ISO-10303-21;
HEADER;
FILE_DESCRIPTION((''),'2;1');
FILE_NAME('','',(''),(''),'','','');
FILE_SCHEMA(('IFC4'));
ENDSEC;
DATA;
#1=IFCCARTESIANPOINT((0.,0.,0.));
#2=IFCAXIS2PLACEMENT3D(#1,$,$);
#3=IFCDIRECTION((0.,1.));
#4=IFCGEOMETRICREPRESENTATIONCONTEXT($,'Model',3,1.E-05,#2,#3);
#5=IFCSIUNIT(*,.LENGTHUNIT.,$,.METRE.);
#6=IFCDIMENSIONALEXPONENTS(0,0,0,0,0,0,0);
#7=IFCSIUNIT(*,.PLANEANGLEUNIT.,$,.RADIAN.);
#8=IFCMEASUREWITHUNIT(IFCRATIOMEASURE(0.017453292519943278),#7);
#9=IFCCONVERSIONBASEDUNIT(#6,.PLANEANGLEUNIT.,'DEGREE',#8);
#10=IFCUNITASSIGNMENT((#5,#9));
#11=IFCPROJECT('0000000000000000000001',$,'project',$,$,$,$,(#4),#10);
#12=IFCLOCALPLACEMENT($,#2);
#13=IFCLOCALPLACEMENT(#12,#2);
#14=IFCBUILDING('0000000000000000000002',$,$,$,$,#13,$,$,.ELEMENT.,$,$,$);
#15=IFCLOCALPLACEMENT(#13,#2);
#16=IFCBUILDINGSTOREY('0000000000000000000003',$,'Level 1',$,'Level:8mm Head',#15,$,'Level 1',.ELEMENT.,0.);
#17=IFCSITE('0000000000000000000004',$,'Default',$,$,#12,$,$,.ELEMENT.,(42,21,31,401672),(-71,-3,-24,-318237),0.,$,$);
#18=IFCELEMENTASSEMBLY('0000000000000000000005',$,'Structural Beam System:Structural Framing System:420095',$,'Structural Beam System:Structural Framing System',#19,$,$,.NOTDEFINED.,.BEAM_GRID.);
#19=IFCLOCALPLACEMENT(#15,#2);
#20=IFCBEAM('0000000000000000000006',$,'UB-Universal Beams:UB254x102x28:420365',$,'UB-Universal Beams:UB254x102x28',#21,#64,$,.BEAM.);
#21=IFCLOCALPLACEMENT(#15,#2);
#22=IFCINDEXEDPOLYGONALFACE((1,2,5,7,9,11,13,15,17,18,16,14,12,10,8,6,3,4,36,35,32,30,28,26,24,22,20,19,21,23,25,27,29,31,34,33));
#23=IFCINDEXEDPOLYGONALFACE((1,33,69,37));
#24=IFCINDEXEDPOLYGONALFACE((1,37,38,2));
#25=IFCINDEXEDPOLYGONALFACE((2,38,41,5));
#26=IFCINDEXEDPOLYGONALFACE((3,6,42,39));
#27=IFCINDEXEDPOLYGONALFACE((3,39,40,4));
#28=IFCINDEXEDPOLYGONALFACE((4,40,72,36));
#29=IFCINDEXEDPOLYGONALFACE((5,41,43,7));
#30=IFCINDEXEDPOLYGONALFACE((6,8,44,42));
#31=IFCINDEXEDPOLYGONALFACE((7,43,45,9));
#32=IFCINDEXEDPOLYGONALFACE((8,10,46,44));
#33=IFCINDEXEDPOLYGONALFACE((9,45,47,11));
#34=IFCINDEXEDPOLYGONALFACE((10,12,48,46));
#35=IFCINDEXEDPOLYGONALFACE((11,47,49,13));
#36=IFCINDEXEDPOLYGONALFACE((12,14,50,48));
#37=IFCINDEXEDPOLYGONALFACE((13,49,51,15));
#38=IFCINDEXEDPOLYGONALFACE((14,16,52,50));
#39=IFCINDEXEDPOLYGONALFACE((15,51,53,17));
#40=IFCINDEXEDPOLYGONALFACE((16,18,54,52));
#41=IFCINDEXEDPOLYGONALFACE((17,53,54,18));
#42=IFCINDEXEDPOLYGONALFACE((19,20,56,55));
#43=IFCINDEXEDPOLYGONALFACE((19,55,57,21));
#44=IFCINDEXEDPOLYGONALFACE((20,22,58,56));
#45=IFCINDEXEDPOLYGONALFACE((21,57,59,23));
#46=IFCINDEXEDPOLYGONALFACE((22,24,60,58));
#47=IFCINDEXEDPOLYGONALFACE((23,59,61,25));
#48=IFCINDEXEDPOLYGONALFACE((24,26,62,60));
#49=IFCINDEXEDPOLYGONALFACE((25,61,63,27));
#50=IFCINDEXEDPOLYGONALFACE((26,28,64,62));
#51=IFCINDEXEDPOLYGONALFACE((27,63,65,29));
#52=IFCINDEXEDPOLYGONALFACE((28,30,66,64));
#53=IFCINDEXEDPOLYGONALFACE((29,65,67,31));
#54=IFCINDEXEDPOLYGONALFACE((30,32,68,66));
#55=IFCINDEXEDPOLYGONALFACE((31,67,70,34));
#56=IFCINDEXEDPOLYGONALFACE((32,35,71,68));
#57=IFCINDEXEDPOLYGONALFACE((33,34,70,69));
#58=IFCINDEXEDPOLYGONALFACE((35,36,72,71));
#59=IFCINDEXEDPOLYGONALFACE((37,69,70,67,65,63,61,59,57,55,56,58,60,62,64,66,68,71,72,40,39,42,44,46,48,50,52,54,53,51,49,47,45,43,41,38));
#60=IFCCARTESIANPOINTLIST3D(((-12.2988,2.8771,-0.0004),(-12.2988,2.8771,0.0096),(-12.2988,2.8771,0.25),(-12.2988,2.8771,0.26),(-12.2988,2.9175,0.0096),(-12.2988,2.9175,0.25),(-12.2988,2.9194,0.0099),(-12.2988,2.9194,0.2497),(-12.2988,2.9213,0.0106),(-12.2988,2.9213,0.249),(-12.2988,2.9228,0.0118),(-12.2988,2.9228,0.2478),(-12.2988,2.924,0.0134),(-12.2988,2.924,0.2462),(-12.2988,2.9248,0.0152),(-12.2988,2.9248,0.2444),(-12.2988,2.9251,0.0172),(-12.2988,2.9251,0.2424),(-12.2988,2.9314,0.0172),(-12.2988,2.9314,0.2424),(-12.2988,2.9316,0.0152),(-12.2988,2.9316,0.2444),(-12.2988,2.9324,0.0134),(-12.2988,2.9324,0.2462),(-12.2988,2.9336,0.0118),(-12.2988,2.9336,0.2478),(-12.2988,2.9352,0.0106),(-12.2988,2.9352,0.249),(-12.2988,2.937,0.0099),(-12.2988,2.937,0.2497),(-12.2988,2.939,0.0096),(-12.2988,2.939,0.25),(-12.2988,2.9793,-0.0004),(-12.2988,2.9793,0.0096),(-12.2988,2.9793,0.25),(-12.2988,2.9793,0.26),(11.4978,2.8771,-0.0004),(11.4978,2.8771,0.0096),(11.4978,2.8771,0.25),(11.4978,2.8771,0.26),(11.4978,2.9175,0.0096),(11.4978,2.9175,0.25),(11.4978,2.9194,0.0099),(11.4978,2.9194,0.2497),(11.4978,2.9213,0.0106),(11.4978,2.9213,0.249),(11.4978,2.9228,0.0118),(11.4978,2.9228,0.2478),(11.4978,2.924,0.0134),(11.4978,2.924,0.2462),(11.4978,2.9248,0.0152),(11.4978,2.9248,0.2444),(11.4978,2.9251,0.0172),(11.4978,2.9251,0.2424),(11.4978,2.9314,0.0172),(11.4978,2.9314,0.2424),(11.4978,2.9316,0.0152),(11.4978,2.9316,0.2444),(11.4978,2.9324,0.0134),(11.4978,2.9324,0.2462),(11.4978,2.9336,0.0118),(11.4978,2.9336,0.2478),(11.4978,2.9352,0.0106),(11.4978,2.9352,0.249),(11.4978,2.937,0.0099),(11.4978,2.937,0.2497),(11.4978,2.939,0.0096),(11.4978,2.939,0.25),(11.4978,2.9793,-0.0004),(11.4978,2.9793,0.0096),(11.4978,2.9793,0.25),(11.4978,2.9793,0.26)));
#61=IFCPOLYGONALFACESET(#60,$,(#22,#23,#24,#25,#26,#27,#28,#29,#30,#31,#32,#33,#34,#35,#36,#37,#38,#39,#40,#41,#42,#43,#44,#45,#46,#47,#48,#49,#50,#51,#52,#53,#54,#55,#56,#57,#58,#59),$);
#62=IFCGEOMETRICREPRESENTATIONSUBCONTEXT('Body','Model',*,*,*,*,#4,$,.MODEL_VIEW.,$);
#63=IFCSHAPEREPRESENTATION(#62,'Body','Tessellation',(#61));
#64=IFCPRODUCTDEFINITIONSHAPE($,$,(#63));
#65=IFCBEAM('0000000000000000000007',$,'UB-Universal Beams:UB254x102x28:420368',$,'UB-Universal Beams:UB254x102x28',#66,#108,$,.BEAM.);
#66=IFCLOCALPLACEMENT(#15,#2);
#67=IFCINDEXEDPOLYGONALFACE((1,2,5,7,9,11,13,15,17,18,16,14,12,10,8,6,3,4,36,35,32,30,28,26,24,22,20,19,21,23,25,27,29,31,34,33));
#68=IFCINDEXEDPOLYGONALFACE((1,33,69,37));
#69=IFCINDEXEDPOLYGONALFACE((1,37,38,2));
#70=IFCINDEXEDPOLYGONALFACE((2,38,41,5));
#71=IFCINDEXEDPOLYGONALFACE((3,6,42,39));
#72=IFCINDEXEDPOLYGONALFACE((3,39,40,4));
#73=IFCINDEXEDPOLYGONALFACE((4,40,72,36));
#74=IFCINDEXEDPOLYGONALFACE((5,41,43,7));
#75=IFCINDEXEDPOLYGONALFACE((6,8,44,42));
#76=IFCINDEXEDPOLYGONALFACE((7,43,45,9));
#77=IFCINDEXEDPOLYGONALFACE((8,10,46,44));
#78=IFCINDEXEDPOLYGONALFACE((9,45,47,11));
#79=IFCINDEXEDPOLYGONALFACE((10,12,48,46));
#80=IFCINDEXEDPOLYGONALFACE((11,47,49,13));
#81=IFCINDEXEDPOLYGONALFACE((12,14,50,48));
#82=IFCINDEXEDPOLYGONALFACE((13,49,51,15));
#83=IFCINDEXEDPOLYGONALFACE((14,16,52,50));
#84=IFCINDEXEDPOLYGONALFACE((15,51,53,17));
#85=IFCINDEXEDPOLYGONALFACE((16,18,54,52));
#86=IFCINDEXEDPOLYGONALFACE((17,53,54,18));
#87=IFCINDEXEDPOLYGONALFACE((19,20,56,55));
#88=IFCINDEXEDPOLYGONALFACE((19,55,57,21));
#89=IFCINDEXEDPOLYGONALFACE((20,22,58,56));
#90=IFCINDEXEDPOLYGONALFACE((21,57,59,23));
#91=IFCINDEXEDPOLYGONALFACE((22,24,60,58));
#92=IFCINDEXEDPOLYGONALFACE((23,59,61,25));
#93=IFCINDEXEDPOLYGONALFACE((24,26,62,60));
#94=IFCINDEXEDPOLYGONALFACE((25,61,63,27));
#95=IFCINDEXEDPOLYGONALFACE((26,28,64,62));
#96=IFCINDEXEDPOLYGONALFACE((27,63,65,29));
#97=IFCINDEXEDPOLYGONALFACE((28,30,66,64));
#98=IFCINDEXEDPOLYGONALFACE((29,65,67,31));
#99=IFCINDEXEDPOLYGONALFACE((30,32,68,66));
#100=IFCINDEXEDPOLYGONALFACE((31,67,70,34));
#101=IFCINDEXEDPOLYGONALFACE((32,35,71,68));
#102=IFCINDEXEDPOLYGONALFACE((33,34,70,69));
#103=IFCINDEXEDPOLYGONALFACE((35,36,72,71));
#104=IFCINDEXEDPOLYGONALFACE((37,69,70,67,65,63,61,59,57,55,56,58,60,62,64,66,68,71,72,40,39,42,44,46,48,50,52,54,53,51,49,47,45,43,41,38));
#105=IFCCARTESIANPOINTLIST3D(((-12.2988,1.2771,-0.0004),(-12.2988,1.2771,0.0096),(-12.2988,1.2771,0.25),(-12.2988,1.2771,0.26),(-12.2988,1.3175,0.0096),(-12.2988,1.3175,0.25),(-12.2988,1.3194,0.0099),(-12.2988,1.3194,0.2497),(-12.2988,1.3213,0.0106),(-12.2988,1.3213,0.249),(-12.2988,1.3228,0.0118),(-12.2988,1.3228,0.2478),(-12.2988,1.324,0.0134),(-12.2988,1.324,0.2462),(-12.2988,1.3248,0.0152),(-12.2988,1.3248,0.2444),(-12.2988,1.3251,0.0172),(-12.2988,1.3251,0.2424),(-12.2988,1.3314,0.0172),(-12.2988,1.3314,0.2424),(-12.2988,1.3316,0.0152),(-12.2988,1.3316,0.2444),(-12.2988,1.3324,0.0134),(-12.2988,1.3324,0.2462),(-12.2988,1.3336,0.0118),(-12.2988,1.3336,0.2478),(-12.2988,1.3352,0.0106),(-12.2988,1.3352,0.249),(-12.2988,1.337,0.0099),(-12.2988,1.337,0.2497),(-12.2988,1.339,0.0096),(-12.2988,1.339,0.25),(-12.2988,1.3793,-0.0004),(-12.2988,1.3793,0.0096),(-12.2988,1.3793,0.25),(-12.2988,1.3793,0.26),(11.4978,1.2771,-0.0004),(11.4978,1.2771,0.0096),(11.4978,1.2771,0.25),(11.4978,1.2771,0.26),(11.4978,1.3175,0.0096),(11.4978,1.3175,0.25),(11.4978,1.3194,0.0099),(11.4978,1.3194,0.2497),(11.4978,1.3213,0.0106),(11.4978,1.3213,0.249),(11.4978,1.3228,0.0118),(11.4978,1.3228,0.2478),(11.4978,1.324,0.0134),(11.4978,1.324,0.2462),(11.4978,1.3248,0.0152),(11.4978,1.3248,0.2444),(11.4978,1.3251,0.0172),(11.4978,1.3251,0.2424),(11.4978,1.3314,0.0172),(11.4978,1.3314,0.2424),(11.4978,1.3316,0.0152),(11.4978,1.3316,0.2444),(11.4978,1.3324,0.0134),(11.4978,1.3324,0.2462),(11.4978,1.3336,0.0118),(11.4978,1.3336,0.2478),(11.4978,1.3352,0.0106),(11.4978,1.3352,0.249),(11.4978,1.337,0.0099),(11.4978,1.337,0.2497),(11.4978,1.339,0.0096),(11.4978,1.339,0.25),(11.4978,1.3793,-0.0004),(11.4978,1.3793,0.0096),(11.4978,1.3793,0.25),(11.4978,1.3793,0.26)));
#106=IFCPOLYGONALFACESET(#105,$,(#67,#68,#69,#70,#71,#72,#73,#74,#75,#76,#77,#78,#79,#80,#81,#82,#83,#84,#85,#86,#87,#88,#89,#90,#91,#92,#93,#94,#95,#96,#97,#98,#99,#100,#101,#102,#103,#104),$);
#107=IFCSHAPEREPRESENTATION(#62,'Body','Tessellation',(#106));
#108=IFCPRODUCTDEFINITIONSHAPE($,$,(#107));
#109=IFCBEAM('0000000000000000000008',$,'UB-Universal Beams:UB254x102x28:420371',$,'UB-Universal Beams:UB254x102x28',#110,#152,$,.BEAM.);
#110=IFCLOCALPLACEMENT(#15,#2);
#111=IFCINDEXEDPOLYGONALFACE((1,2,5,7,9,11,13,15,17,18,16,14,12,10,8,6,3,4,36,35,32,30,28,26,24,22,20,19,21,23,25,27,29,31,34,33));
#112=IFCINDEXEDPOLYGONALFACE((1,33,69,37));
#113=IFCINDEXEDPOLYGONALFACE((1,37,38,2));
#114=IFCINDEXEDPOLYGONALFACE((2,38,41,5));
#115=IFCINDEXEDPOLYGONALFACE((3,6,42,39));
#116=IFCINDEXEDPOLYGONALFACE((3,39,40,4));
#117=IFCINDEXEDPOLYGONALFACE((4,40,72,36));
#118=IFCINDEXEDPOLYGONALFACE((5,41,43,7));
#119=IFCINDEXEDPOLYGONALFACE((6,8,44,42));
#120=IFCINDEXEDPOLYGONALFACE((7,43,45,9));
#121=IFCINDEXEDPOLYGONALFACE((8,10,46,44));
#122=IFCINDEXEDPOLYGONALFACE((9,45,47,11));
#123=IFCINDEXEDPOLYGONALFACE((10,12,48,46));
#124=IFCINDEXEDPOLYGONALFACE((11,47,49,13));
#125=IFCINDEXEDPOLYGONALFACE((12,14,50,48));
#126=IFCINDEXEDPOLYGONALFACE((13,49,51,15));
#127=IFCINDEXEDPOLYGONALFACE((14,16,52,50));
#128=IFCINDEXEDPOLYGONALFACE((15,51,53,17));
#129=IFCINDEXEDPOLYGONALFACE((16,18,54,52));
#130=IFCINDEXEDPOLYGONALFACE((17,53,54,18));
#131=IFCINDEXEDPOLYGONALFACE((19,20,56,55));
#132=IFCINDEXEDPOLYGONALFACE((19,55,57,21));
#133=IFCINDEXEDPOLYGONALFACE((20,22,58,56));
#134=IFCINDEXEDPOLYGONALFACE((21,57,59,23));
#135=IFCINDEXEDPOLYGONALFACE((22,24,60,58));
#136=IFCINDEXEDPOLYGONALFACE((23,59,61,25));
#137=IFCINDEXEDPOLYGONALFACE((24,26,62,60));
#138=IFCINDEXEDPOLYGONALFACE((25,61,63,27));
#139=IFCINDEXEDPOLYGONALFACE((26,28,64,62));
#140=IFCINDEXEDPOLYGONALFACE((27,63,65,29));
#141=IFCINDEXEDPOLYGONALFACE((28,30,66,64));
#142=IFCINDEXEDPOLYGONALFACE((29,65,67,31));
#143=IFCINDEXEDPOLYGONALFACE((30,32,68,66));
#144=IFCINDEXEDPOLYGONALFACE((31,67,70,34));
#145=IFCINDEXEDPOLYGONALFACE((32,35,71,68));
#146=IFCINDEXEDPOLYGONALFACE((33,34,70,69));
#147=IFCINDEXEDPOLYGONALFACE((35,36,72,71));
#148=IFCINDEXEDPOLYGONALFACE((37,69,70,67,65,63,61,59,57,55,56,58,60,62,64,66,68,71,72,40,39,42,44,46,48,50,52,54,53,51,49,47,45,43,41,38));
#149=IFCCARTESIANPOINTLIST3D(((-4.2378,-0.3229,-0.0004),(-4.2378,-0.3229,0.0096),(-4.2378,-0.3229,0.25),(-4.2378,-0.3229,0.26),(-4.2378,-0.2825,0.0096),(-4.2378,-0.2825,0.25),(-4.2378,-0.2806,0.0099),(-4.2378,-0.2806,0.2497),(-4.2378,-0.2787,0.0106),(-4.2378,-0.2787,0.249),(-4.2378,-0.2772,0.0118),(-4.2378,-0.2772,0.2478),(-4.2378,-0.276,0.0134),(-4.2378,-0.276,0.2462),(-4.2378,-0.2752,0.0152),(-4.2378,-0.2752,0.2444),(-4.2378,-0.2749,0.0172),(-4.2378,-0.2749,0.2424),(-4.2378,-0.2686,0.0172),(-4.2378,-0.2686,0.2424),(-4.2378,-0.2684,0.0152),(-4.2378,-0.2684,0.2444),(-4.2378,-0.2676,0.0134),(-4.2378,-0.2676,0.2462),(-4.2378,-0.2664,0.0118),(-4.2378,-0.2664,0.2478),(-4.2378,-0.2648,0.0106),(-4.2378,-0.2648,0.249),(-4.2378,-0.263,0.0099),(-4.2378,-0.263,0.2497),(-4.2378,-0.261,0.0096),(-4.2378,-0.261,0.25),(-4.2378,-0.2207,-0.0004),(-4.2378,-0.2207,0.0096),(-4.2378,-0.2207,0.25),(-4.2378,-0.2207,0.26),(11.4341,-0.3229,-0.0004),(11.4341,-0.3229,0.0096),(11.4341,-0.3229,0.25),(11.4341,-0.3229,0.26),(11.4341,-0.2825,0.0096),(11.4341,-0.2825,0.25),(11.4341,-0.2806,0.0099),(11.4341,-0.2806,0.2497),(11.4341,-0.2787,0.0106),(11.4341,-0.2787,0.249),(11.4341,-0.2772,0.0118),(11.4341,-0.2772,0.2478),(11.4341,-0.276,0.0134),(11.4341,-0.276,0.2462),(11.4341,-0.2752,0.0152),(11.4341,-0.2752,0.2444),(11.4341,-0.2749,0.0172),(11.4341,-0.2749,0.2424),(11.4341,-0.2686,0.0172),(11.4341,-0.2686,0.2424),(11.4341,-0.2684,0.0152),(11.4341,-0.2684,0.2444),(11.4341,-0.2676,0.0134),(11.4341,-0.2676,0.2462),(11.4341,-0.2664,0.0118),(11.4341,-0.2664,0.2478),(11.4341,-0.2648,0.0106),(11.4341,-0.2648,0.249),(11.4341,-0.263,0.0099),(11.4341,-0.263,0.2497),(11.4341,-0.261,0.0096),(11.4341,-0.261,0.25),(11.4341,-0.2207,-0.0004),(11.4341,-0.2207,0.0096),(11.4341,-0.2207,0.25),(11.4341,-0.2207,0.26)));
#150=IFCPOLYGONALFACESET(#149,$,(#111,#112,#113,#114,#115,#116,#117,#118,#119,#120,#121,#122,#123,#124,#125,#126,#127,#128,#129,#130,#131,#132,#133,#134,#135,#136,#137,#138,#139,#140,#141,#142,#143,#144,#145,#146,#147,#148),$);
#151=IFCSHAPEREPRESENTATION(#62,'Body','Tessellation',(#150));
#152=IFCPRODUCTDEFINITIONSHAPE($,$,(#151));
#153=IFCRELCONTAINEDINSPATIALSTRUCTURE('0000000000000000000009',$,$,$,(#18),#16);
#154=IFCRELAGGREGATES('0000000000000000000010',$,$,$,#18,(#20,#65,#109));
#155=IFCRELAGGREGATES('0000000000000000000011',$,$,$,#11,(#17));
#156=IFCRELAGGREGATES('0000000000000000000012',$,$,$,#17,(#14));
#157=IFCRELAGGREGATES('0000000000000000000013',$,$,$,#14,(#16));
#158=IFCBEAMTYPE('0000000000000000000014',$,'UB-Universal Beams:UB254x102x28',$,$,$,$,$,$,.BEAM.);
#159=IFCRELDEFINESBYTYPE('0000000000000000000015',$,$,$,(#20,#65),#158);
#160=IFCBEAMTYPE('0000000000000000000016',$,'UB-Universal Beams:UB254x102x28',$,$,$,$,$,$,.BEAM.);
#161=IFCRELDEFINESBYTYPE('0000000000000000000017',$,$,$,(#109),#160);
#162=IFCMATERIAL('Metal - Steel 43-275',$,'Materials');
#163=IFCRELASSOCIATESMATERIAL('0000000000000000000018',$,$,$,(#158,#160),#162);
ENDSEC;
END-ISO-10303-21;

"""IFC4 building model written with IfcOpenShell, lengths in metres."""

from ifc_helpers import new_model, entity, si_unit, converted_unit, direction, frame, frame_2d, origin, place, context, subcontext, project, spatial, i_section, extrude, source, transform, mapped, material, material_profile, profile_set, type_object, type_shapes, element, aggregate, save


model = new_model("IFC4")

# Units and contexts
model_context = context("Model", 3, precision=1e-05, world=origin(), true_north=direction((0.0, 1.0)))
body_context = subcontext(model_context, "Body", "Model", "MODEL_VIEW")
ifc_project = project(units=[si_unit("LENGTHUNIT", "METRE"), converted_unit("PLANEANGLEUNIT", "DEGREE", entity("IfcRatioMeasure", 0.017453292519943278), si_unit("PLANEANGLEUNIT", "RADIAN"), dimensions=[0, 0, 0, 0, 0, 0, 0])], contexts=[model_context])

# Site, building, storey
site_placement = place(None, origin())
site = spatial("IfcSite", under=ifc_project, at=site_placement, Name="Default", CompositionType="ELEMENT", RefLatitude=(42, 21, 31, 401672), RefLongitude=(-71, -3, -24, -318237), RefElevation=0.0)
building_placement = place(site_placement, origin())
building = spatial("IfcBuilding", under=site, at=building_placement, CompositionType="ELEMENT")
storey_placement = place(building_placement, origin())
storey = spatial("IfcBuildingStorey", under=building, at=storey_placement, Name="Level 1", ObjectType="Level:8mm Head", LongName="Level 1", CompositionType="ELEMENT", Elevation=0.0)

# Shared definitions
ifc_material_1 = material(Name="Metal - Steel 43-275", Category="Materials")

# Element assembly, beams
assembly_placement = place(storey_placement, origin())
assembly = element("IfcElementAssembly", 1, at=assembly_placement, inside=storey, Name="Structural Beam System:Structural Framing System:420095", ObjectType="Structural Beam System:Structural Framing System", AssemblyPlace="NOTDEFINED", PredefinedType="BEAM_GRID")
ifc_material_profile_1 = material_profile(ifc_material_1, i_section(OverallWidth=0.1022, OverallDepth=0.2604, WebThickness=0.0063, FlangeThickness=0.01, FilletRadius=0.0076, at=frame_2d((0.0, 0.0), x_axis=(0.0, 1.0))), Name="UB254x102x28")
ifc_profile_set_1 = profile_set([ifc_material_profile_1], Name="UB254x102x28")
beam_type_1 = type_object("IfcBeamType", Name="UB-Universal Beams:UB254x102x28", PredefinedType="BEAM", material=ifc_profile_set_1)
shared_shape_1 = source(origin(), body_context, "Body", "SweptSolid", [
    extrude(i_section(OverallWidth=0.1022, OverallDepth=0.2604, WebThickness=0.0063, FlangeThickness=0.01, FilletRadius=0.0076, at=frame_2d((0.0, 0.0), x_axis=(0.0, 1.0))), frame((-11.8983, 0.0, 0.0), z_axis=(1.0, 0.0, 0.0), x_axis=(0.0, 0.0, -1.0)), (0.0, 0.0, 1.0), 23.7966),
])
type_shapes(beam_type_1, [shared_shape_1])
beam_1_placement = place(assembly_placement, frame((-0.4005, 2.9282, 0.1298)))
beam_1 = element("IfcBeam", 2, at=beam_1_placement, type_object=beam_type_1, Name="UB-Universal Beams:UB254x102x28:420365", ObjectType="UB-Universal Beams:UB254x102x28", PredefinedType="BEAM", context=body_context, shape_type="MappedRepresentation", body=[
    mapped(shared_shape_1, transform((0.0, 0.0, 0.0), scale=1.0)),
])
beam_2_placement = place(assembly_placement, frame((-0.4005, 1.3282, 0.1298)))
beam_2 = element("IfcBeam", 3, at=beam_2_placement, type_object=beam_type_1, Name="UB-Universal Beams:UB254x102x28:420368", ObjectType="UB-Universal Beams:UB254x102x28", PredefinedType="BEAM", context=body_context, shape_type="MappedRepresentation", body=[
    mapped(shared_shape_1, transform((0.0, 0.0, 0.0), scale=1.0)),
])
beam_type_2 = type_object("IfcBeamType", Name="UB-Universal Beams:UB254x102x28", PredefinedType="BEAM", material=ifc_profile_set_1)
shared_shape_2 = source(origin(), body_context, "Body", "SweptSolid", [
    extrude(i_section(OverallWidth=0.1022, OverallDepth=0.2604, WebThickness=0.0063, FlangeThickness=0.01, FilletRadius=0.0076, at=frame_2d((0.0, 0.0), x_axis=(0.0, 1.0))), frame((-7.8818, 0.0, 0.0), z_axis=(1.0, 0.0, 0.0), x_axis=(0.0, 0.0, -1.0)), (0.0, 0.0, 1.0), 15.6719),
])
type_shapes(beam_type_2, [shared_shape_2])
beam_3_placement = place(assembly_placement, frame((3.644, -0.2718, 0.1298)))
beam_3 = element("IfcBeam", 4, at=beam_3_placement, type_object=beam_type_2, Name="UB-Universal Beams:UB254x102x28:420371", ObjectType="UB-Universal Beams:UB254x102x28", PredefinedType="BEAM", context=body_context, shape_type="MappedRepresentation", body=[
    mapped(shared_shape_2, transform((0.0, 0.0, 0.0), scale=1.0)),
])
aggregate(assembly, [beam_1, beam_2, beam_3])

save(model, "model.ifc")
